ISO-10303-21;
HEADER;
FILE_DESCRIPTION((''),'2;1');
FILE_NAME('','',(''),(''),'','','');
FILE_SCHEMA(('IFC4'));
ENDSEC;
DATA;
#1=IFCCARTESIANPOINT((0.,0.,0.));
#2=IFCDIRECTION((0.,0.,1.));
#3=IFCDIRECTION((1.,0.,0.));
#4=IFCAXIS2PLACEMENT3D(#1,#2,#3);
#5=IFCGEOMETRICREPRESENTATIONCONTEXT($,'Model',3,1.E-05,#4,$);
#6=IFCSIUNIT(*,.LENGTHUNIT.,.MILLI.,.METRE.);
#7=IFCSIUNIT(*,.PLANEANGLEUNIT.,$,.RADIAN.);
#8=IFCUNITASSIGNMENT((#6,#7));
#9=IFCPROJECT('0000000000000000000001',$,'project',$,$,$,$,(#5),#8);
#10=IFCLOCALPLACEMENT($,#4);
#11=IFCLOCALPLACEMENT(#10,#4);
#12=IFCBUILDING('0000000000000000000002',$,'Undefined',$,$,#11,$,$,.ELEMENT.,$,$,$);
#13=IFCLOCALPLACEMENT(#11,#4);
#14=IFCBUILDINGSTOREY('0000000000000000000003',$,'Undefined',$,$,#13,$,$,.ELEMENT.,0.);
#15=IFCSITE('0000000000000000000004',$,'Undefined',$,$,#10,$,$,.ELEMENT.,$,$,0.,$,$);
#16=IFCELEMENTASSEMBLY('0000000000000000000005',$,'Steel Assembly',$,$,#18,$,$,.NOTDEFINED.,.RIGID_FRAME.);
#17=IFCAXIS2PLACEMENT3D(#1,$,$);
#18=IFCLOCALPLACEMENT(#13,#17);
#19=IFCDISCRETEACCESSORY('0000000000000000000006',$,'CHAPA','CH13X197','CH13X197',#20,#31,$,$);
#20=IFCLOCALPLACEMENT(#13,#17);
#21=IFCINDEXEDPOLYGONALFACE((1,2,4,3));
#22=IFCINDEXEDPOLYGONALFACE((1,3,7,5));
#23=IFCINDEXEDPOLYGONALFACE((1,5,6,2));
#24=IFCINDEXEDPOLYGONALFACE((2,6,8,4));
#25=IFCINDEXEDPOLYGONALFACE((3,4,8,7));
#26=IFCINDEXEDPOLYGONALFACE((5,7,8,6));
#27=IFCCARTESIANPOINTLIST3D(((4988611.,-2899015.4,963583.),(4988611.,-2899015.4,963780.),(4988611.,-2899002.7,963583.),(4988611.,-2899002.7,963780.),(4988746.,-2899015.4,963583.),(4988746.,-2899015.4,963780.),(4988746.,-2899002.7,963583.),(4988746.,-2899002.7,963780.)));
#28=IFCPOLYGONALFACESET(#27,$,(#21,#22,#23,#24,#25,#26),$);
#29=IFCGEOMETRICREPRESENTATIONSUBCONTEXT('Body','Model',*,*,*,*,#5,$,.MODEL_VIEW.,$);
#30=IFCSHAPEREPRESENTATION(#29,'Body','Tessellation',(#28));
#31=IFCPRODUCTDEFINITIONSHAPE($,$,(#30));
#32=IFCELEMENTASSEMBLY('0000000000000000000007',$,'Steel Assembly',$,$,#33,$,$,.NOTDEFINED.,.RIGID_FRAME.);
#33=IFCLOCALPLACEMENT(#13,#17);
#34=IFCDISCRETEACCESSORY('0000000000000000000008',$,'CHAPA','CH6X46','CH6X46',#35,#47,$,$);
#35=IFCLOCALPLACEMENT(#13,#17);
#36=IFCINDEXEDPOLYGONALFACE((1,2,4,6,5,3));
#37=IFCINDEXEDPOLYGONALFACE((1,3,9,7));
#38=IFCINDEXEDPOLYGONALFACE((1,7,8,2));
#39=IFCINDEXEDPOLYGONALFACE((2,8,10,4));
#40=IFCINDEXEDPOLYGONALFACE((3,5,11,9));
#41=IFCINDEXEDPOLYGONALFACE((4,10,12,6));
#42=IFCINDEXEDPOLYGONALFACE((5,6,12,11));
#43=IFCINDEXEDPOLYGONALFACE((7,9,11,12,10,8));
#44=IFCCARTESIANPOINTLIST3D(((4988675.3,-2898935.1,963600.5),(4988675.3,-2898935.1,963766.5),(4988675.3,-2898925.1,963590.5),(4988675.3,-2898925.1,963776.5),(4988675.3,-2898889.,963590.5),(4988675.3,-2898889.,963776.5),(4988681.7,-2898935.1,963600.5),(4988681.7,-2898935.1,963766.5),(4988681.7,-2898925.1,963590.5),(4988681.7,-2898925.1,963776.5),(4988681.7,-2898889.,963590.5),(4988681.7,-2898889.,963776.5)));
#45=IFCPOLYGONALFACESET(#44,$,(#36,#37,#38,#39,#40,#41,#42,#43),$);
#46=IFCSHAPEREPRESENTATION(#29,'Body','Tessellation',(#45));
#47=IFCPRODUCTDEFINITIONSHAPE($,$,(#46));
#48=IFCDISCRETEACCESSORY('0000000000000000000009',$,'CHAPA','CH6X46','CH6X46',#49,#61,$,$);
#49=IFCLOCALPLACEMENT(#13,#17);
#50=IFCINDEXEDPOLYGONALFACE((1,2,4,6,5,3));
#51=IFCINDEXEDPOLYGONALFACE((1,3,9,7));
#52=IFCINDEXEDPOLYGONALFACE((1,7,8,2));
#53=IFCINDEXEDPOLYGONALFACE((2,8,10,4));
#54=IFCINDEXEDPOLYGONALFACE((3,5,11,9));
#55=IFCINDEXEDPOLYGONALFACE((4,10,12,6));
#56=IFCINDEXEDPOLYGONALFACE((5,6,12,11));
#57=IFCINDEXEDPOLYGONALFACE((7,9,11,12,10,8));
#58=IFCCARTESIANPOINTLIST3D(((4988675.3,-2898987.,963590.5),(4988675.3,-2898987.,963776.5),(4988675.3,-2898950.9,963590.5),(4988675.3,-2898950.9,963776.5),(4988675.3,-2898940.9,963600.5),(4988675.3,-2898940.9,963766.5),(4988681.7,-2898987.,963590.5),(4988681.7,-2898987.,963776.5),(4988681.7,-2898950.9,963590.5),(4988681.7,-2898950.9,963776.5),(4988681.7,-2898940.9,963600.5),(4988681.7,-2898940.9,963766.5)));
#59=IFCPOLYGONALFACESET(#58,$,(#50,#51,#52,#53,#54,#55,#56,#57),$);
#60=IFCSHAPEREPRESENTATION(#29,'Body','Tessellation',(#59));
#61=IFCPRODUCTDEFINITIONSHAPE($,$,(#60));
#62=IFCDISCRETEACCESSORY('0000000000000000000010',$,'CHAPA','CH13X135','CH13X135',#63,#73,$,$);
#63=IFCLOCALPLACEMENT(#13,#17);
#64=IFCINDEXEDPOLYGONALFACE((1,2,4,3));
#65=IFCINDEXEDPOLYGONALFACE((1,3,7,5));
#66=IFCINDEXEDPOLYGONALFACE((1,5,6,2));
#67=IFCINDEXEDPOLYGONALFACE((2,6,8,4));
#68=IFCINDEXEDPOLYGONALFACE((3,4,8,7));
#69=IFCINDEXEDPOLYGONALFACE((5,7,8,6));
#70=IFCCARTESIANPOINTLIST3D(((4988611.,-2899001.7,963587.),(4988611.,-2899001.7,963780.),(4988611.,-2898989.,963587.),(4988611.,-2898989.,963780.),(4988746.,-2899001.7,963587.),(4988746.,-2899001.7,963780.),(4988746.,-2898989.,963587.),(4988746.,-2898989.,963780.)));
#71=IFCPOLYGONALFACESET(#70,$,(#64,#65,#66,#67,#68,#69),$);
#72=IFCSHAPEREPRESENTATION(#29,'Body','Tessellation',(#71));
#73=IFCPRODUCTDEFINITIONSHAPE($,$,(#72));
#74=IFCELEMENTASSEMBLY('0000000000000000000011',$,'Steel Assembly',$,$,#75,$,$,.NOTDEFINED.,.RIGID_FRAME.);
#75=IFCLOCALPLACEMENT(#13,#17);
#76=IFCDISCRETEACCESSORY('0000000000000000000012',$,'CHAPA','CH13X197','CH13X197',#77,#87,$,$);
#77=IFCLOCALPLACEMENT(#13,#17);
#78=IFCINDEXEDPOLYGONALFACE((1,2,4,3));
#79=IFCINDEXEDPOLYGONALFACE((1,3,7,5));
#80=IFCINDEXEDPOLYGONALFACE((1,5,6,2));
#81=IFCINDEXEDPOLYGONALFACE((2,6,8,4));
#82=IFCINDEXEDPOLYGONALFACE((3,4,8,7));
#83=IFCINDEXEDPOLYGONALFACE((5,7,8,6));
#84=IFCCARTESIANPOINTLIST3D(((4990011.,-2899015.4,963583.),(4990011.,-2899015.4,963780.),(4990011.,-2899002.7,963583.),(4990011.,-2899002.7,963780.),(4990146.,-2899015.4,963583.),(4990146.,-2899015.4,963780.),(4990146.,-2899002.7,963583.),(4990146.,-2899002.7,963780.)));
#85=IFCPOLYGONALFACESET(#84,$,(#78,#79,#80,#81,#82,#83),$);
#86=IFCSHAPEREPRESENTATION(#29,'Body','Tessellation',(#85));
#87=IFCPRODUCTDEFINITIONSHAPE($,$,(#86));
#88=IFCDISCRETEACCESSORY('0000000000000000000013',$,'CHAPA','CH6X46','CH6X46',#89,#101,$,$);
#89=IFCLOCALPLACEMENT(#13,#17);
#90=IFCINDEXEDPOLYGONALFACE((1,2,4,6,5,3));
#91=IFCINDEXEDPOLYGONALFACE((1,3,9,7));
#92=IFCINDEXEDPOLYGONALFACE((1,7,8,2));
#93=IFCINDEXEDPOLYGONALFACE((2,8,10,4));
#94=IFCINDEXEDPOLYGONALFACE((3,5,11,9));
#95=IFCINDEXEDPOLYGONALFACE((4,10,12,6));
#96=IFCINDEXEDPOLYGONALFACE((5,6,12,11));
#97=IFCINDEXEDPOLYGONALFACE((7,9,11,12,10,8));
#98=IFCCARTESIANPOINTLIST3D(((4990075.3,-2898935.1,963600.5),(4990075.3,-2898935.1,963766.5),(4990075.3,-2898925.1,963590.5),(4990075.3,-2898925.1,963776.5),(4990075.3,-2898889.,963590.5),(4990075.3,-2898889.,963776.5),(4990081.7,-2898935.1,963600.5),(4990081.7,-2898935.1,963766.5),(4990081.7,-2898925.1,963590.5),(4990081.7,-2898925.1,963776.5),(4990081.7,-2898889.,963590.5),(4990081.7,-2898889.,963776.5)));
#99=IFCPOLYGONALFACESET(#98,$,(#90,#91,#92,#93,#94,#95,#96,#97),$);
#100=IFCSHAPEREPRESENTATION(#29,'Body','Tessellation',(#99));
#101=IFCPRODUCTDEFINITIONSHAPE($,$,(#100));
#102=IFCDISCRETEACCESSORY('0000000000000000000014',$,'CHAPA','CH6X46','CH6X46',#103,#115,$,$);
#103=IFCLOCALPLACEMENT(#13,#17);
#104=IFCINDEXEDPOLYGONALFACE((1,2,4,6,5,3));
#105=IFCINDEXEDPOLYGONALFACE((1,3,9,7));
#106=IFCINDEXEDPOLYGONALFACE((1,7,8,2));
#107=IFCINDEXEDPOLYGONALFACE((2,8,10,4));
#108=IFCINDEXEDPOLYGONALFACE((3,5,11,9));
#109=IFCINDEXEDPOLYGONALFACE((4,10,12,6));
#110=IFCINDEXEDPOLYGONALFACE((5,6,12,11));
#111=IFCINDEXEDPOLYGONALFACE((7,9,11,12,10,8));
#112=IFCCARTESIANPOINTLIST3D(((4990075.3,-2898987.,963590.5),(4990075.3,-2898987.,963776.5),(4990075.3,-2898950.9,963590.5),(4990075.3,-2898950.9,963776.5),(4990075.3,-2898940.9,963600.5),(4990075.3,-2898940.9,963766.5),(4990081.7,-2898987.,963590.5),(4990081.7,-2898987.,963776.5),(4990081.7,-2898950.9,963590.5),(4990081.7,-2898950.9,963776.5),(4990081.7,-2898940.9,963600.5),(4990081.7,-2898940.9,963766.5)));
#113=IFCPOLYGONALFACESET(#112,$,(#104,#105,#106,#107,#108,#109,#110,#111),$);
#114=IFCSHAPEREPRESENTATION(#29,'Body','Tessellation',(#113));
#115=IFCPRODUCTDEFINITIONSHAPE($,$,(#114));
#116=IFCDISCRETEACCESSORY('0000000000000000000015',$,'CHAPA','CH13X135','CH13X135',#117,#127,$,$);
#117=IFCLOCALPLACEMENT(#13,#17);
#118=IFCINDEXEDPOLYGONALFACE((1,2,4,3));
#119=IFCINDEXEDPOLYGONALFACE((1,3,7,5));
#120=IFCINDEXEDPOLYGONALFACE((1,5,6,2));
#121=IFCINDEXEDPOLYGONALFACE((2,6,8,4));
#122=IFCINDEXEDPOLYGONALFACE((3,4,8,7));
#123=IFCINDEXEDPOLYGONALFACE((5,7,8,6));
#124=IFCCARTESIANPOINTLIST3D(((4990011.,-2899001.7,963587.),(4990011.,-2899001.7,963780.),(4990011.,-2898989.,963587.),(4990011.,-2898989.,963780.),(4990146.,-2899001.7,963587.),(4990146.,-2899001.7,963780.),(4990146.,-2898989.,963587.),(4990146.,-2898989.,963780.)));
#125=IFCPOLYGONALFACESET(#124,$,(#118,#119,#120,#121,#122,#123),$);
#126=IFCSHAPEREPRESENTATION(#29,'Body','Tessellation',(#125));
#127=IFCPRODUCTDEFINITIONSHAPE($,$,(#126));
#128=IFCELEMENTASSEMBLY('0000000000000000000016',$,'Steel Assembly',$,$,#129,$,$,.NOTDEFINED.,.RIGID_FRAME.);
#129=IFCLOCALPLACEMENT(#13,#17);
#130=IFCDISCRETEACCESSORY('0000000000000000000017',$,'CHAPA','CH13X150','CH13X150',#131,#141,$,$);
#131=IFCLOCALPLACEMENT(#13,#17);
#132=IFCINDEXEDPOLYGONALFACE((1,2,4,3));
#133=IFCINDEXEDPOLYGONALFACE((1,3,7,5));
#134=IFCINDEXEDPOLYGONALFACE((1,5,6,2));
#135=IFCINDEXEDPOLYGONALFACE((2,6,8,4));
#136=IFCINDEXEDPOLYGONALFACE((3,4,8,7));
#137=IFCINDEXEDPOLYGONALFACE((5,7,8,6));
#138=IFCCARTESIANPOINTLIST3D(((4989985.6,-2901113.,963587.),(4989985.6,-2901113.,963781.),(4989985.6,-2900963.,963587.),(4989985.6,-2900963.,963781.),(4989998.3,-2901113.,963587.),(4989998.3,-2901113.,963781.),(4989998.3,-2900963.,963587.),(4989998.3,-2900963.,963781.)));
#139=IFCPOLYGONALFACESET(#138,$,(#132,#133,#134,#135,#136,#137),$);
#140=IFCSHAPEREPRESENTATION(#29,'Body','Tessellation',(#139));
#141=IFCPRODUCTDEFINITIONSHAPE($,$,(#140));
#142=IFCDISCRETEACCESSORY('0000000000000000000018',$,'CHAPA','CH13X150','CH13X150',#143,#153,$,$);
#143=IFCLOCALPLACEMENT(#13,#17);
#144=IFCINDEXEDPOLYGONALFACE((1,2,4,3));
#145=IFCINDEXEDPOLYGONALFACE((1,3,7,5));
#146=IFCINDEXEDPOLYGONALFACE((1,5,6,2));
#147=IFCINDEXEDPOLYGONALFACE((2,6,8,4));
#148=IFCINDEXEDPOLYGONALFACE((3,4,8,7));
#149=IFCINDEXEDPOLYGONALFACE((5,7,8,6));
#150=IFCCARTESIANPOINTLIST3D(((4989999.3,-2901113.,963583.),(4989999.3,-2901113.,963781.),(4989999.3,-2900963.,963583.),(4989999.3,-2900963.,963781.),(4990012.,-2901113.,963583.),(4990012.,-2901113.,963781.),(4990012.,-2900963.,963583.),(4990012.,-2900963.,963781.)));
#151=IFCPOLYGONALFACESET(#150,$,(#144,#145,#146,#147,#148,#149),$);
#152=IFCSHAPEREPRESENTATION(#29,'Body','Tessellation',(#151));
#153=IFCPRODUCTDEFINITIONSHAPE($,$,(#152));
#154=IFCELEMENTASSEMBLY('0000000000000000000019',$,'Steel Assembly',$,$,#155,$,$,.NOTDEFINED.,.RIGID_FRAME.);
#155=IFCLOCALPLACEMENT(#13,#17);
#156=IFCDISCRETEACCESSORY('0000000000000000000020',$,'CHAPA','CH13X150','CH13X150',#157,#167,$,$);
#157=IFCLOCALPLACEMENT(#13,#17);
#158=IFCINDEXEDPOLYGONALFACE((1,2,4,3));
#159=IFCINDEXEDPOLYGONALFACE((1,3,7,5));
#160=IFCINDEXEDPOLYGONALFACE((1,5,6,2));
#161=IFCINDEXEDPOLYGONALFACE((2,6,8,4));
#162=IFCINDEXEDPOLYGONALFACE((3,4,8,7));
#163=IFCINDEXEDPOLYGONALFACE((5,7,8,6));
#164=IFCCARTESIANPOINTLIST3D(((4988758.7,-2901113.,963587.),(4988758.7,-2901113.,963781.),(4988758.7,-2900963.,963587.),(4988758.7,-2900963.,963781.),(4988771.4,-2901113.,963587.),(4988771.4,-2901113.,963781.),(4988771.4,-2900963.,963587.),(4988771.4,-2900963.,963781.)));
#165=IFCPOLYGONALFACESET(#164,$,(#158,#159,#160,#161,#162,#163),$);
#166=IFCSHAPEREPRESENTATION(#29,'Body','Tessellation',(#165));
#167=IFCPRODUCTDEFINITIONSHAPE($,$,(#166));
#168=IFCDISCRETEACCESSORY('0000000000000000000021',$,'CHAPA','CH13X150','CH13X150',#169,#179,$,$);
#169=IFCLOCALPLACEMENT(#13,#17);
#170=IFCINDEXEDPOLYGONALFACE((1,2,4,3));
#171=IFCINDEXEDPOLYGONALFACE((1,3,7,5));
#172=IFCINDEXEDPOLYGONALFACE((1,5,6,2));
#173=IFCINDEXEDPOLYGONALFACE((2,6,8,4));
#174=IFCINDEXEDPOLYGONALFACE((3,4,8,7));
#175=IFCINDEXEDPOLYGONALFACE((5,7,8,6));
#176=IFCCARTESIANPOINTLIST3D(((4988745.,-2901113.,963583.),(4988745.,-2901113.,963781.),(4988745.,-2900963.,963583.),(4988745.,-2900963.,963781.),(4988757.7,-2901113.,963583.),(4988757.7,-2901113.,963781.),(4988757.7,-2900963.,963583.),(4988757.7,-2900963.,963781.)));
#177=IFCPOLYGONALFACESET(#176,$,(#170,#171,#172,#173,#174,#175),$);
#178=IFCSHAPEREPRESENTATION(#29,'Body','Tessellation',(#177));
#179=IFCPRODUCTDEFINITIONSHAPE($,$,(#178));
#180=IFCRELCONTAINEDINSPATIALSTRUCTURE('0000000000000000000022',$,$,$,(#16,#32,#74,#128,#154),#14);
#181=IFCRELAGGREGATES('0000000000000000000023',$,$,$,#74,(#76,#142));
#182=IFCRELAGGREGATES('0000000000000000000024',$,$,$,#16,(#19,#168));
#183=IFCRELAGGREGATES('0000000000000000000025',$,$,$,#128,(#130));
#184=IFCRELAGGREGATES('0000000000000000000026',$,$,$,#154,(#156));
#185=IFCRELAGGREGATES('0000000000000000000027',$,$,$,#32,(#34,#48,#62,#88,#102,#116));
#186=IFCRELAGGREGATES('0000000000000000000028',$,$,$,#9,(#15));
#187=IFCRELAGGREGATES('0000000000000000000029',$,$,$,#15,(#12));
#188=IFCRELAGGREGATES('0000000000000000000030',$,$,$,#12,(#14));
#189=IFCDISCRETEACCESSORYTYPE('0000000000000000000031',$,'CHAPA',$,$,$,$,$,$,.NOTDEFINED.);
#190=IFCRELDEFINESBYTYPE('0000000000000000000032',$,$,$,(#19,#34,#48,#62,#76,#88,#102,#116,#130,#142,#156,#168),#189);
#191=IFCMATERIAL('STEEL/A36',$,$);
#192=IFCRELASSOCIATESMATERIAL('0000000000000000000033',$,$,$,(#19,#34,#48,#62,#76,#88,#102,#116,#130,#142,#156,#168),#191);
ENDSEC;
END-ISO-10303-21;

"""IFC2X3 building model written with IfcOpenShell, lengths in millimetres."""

from ifc_helpers import new_model, si_unit, frame, origin_with_axes, place, context, subcontext, project, spatial, polyline, outline, extrude, material, type_object, element, aggregate, save


model = new_model("IFC2X3")

# Units and contexts
model_context = context("Model", 3, precision=1e-05, world=origin_with_axes())
body_context = subcontext(model_context, "Body", "Model", "MODEL_VIEW")
ifc_project = project(units=[si_unit("LENGTHUNIT", "METRE", prefix="MILLI"), si_unit("PLANEANGLEUNIT", "RADIAN")], contexts=[model_context])

# Site, building, storey
site_placement = place(None, origin_with_axes())
site = spatial("IfcSite", under=ifc_project, at=site_placement, Name="Undefined", CompositionType="ELEMENT", RefElevation=0.0)
building_placement = place(site_placement, origin_with_axes())
building = spatial("IfcBuilding", under=site, at=building_placement, Name="Undefined", CompositionType="ELEMENT")
storey_placement = place(building_placement, origin_with_axes())
storey = spatial("IfcBuildingStorey", under=building, at=storey_placement, Name="Undefined", CompositionType="ELEMENT", Elevation=0.0)

# Element assembly, discrete accessory
assembly_1_placement = place(storey_placement, origin_with_axes())
assembly_1 = element("IfcElementAssembly", 1, at=assembly_1_placement, inside=storey, Name="Steel Assembly", AssemblyPlace="NOTDEFINED", PredefinedType="RIGID_FRAME")
ifc_material_1 = material(Name="STEEL/A36")
discrete_accessory_type_1 = type_object("IfcDiscreteAccessoryType", Name="CHAPA")
discrete_accessory_1_placement = place(assembly_1_placement, frame((4988678.5, -2899009.1, 963780.0), z_axis=(0.0, -1.0, 0.0), x_axis=(0.0, 0.0, -1.0)))
discrete_accessory_1 = element("IfcDiscreteAccessory", 2, at=discrete_accessory_1_placement, type_object=discrete_accessory_type_1, material=ifc_material_1, Name="CHAPA", Description="CH13X197", ObjectType="CH13X197", context=body_context, shape_type="SweptSolid", body=[
    extrude(outline(polyline([(197.0, -67.5), (0.0, -67.5), (0.0, 67.5), (197.0, 67.5), (197.0, -67.5)])), frame((0.0, 0.0, -6.3), z_axis=(0.0, 0.0, 1.0), x_axis=(1.0, 0.0, 0.0)), (0.0, 0.0, 1.0), 12.7),
])

# Element assembly, discrete accessories
assembly_2_placement = place(storey_placement, origin_with_axes())
assembly_2 = element("IfcElementAssembly", 3, at=assembly_2_placement, inside=storey, Name="Steel Assembly", AssemblyPlace="NOTDEFINED", PredefinedType="RIGID_FRAME")
discrete_accessory_2_placement = place(assembly_2_placement, frame((4988678.5, -2898935.1, 963776.5), z_axis=(-1.0, 0.0, 0.0), x_axis=(0.0, 1.0, 0.0)))
discrete_accessory_2 = element("IfcDiscreteAccessory", 4, at=discrete_accessory_2_placement, type_object=discrete_accessory_type_1, material=ifc_material_1, Name="CHAPA", Description="CH6X46", ObjectType="CH6X46", context=body_context, shape_type="SweptSolid", body=[
    extrude(outline(polyline([(0.0, 10.0), (10.0, 0.0), (46.1, 0.0), (46.1, 186.0), (10.0, 186.0), (0.0, 176.0), (0.0, 10.0)])), frame((0.0, 0.0, -3.2), z_axis=(0.0, 0.0, 1.0), x_axis=(1.0, 0.0, 0.0)), (0.0, 0.0, 1.0), 6.4),
])
discrete_accessory_3_placement = place(assembly_2_placement, frame((4988678.5, -2898940.9, 963776.5), z_axis=(1.0, 0.0, 0.0), x_axis=(0.0, -1.0, 0.0)))
discrete_accessory_3 = element("IfcDiscreteAccessory", 5, at=discrete_accessory_3_placement, type_object=discrete_accessory_type_1, material=ifc_material_1, Name="CHAPA", Description="CH6X46", ObjectType="CH6X46", context=body_context, shape_type="SweptSolid", body=[
    extrude(outline(polyline([(0.0, 10.0), (10.0, 0.0), (46.1, 0.0), (46.1, 186.0), (10.0, 186.0), (0.0, 176.0), (0.0, 10.0)])), frame((0.0, 0.0, -3.2), z_axis=(0.0, 0.0, 1.0), x_axis=(1.0, 0.0, 0.0)), (0.0, 0.0, 1.0), 6.4),
])
discrete_accessory_4_placement = place(assembly_2_placement, frame((4988678.5, -2898995.4, 963780.0), z_axis=(0.0, -1.0, 0.0), x_axis=(0.0, 0.0, -1.0)))
discrete_accessory_4 = element("IfcDiscreteAccessory", 6, at=discrete_accessory_4_placement, type_object=discrete_accessory_type_1, material=ifc_material_1, Name="CHAPA", Description="CH13X135", ObjectType="CH13X135", context=body_context, shape_type="SweptSolid", body=[
    extrude(outline(polyline([(193.0, -67.5), (0.0, -67.5), (0.0, 67.5), (193.0, 67.5), (193.0, -67.5)])), frame((0.0, 0.0, -6.3), z_axis=(0.0, 0.0, 1.0), x_axis=(1.0, 0.0, 0.0)), (0.0, 0.0, 1.0), 12.7),
])

# Element assembly, discrete accessory
assembly_3_placement = place(storey_placement, origin_with_axes())
assembly_3 = element("IfcElementAssembly", 7, at=assembly_3_placement, inside=storey, Name="Steel Assembly", AssemblyPlace="NOTDEFINED", PredefinedType="RIGID_FRAME")
discrete_accessory_5_placement = place(assembly_3_placement, frame((4990078.5, -2899009.1, 963780.0), z_axis=(0.0, -1.0, 0.0), x_axis=(0.0, 0.0, -1.0)))
discrete_accessory_5 = element("IfcDiscreteAccessory", 8, at=discrete_accessory_5_placement, type_object=discrete_accessory_type_1, material=ifc_material_1, Name="CHAPA", Description="CH13X197", ObjectType="CH13X197", context=body_context, shape_type="SweptSolid", body=[
    extrude(outline(polyline([(197.0, -67.5), (0.0, -67.5), (0.0, 67.5), (197.0, 67.5), (197.0, -67.5)])), frame((0.0, 0.0, -6.3), z_axis=(0.0, 0.0, 1.0), x_axis=(1.0, 0.0, 0.0)), (0.0, 0.0, 1.0), 12.7),
])

# Discrete accessories
discrete_accessory_6_placement = place(assembly_2_placement, frame((4990078.5, -2898935.1, 963776.5), z_axis=(-1.0, 0.0, 0.0), x_axis=(0.0, 1.0, 0.0)))
discrete_accessory_6 = element("IfcDiscreteAccessory", 9, at=discrete_accessory_6_placement, type_object=discrete_accessory_type_1, material=ifc_material_1, Name="CHAPA", Description="CH6X46", ObjectType="CH6X46", context=body_context, shape_type="SweptSolid", body=[
    extrude(outline(polyline([(0.0, 10.0), (10.0, 0.0), (46.1, 0.0), (46.1, 186.0), (10.0, 186.0), (0.0, 176.0), (0.0, 10.0)])), frame((0.0, 0.0, -3.2), z_axis=(0.0, 0.0, 1.0), x_axis=(1.0, 0.0, 0.0)), (0.0, 0.0, 1.0), 6.4),
])
discrete_accessory_7_placement = place(assembly_2_placement, frame((4990078.5, -2898940.9, 963776.5), z_axis=(1.0, 0.0, 0.0), x_axis=(0.0, -1.0, 0.0)))
discrete_accessory_7 = element("IfcDiscreteAccessory", 10, at=discrete_accessory_7_placement, type_object=discrete_accessory_type_1, material=ifc_material_1, Name="CHAPA", Description="CH6X46", ObjectType="CH6X46", context=body_context, shape_type="SweptSolid", body=[
    extrude(outline(polyline([(0.0, 10.0), (10.0, 0.0), (46.1, 0.0), (46.1, 186.0), (10.0, 186.0), (0.0, 176.0), (0.0, 10.0)])), frame((0.0, 0.0, -3.2), z_axis=(0.0, 0.0, 1.0), x_axis=(1.0, 0.0, 0.0)), (0.0, 0.0, 1.0), 6.4),
])
discrete_accessory_8_placement = place(assembly_2_placement, frame((4990078.5, -2898995.4, 963780.0), z_axis=(0.0, -1.0, 0.0), x_axis=(0.0, 0.0, -1.0)))
discrete_accessory_8 = element("IfcDiscreteAccessory", 11, at=discrete_accessory_8_placement, type_object=discrete_accessory_type_1, material=ifc_material_1, Name="CHAPA", Description="CH13X135", ObjectType="CH13X135", context=body_context, shape_type="SweptSolid", body=[
    extrude(outline(polyline([(193.0, -67.5), (0.0, -67.5), (0.0, 67.5), (193.0, 67.5), (193.0, -67.5)])), frame((0.0, 0.0, -6.3), z_axis=(0.0, 0.0, 1.0), x_axis=(1.0, 0.0, 0.0)), (0.0, 0.0, 1.0), 12.7),
])

# Element assembly, discrete accessory
assembly_4_placement = place(storey_placement, origin_with_axes())
assembly_4 = element("IfcElementAssembly", 12, at=assembly_4_placement, inside=storey, Name="Steel Assembly", AssemblyPlace="NOTDEFINED", PredefinedType="RIGID_FRAME")
discrete_accessory_9_placement = place(assembly_4_placement, frame((4989991.9, -2901038.0, 963781.0), z_axis=(-1.0, 0.0, 0.0), x_axis=(0.0, 0.0, -1.0)))
discrete_accessory_9 = element("IfcDiscreteAccessory", 13, at=discrete_accessory_9_placement, type_object=discrete_accessory_type_1, material=ifc_material_1, Name="CHAPA", Description="CH13X150", ObjectType="CH13X150", context=body_context, shape_type="SweptSolid", body=[
    extrude(outline(polyline([(194.0, 75.0), (194.0, -75.0), (0.0, -75.0), (0.0, 75.0), (194.0, 75.0)])), frame((0.0, 0.0, -6.3), z_axis=(0.0, 0.0, 1.0), x_axis=(1.0, 0.0, 0.0)), (0.0, 0.0, 1.0), 12.7),
])

# Discrete accessory
discrete_accessory_10_placement = place(assembly_3_placement, frame((4990005.6, -2901038.0, 963781.0), z_axis=(-1.0, 0.0, 0.0), x_axis=(0.0, 0.0, -1.0)))
discrete_accessory_10 = element("IfcDiscreteAccessory", 14, at=discrete_accessory_10_placement, type_object=discrete_accessory_type_1, material=ifc_material_1, Name="CHAPA", Description="CH13X150", ObjectType="CH13X150", context=body_context, shape_type="SweptSolid", body=[
    extrude(outline(polyline([(198.0, 75.0), (198.0, -75.0), (0.0, -75.0), (0.0, 75.0), (198.0, 75.0)])), frame((0.0, 0.0, -6.3), z_axis=(0.0, 0.0, 1.0), x_axis=(1.0, 0.0, 0.0)), (0.0, 0.0, 1.0), 12.7),
])
aggregate(assembly_3, [discrete_accessory_5, discrete_accessory_10])

# Element assembly, discrete accessory
assembly_5_placement = place(storey_placement, origin_with_axes())
assembly_5 = element("IfcElementAssembly", 15, at=assembly_5_placement, inside=storey, Name="Steel Assembly", AssemblyPlace="NOTDEFINED", PredefinedType="RIGID_FRAME")
discrete_accessory_11_placement = place(assembly_5_placement, frame((4988765.0, -2901038.0, 963781.0), z_axis=(1.0, 0.0, 0.0), x_axis=(0.0, 0.0, -1.0)))
discrete_accessory_11 = element("IfcDiscreteAccessory", 16, at=discrete_accessory_11_placement, type_object=discrete_accessory_type_1, material=ifc_material_1, Name="CHAPA", Description="CH13X150", ObjectType="CH13X150", context=body_context, shape_type="SweptSolid", body=[
    extrude(outline(polyline([(194.0, -75.0), (0.0, -75.0), (0.0, 75.0), (194.0, 75.0), (194.0, -75.0)])), frame((0.0, 0.0, -6.3), z_axis=(0.0, 0.0, 1.0), x_axis=(1.0, 0.0, 0.0)), (0.0, 0.0, 1.0), 12.7),
])

# Discrete accessory
discrete_accessory_12_placement = place(assembly_1_placement, frame((4988751.3, -2901038.0, 963781.0), z_axis=(1.0, 0.0, 0.0), x_axis=(0.0, 0.0, -1.0)))
discrete_accessory_12 = element("IfcDiscreteAccessory", 17, at=discrete_accessory_12_placement, type_object=discrete_accessory_type_1, material=ifc_material_1, Name="CHAPA", Description="CH13X150", ObjectType="CH13X150", context=body_context, shape_type="SweptSolid", body=[
    extrude(outline(polyline([(198.0, -75.0), (0.0, -75.0), (0.0, 75.0), (198.0, 75.0), (198.0, -75.0)])), frame((0.0, 0.0, -6.3), z_axis=(0.0, 0.0, 1.0), x_axis=(1.0, 0.0, 0.0)), (0.0, 0.0, 1.0), 12.7),
])
aggregate(assembly_1, [discrete_accessory_1, discrete_accessory_12])
aggregate(assembly_4, [discrete_accessory_9])

aggregate(assembly_5, [discrete_accessory_11])
aggregate(assembly_2, [discrete_accessory_2, discrete_accessory_3, discrete_accessory_4, discrete_accessory_6, discrete_accessory_7, discrete_accessory_8])

save(model, "model.ifc")
